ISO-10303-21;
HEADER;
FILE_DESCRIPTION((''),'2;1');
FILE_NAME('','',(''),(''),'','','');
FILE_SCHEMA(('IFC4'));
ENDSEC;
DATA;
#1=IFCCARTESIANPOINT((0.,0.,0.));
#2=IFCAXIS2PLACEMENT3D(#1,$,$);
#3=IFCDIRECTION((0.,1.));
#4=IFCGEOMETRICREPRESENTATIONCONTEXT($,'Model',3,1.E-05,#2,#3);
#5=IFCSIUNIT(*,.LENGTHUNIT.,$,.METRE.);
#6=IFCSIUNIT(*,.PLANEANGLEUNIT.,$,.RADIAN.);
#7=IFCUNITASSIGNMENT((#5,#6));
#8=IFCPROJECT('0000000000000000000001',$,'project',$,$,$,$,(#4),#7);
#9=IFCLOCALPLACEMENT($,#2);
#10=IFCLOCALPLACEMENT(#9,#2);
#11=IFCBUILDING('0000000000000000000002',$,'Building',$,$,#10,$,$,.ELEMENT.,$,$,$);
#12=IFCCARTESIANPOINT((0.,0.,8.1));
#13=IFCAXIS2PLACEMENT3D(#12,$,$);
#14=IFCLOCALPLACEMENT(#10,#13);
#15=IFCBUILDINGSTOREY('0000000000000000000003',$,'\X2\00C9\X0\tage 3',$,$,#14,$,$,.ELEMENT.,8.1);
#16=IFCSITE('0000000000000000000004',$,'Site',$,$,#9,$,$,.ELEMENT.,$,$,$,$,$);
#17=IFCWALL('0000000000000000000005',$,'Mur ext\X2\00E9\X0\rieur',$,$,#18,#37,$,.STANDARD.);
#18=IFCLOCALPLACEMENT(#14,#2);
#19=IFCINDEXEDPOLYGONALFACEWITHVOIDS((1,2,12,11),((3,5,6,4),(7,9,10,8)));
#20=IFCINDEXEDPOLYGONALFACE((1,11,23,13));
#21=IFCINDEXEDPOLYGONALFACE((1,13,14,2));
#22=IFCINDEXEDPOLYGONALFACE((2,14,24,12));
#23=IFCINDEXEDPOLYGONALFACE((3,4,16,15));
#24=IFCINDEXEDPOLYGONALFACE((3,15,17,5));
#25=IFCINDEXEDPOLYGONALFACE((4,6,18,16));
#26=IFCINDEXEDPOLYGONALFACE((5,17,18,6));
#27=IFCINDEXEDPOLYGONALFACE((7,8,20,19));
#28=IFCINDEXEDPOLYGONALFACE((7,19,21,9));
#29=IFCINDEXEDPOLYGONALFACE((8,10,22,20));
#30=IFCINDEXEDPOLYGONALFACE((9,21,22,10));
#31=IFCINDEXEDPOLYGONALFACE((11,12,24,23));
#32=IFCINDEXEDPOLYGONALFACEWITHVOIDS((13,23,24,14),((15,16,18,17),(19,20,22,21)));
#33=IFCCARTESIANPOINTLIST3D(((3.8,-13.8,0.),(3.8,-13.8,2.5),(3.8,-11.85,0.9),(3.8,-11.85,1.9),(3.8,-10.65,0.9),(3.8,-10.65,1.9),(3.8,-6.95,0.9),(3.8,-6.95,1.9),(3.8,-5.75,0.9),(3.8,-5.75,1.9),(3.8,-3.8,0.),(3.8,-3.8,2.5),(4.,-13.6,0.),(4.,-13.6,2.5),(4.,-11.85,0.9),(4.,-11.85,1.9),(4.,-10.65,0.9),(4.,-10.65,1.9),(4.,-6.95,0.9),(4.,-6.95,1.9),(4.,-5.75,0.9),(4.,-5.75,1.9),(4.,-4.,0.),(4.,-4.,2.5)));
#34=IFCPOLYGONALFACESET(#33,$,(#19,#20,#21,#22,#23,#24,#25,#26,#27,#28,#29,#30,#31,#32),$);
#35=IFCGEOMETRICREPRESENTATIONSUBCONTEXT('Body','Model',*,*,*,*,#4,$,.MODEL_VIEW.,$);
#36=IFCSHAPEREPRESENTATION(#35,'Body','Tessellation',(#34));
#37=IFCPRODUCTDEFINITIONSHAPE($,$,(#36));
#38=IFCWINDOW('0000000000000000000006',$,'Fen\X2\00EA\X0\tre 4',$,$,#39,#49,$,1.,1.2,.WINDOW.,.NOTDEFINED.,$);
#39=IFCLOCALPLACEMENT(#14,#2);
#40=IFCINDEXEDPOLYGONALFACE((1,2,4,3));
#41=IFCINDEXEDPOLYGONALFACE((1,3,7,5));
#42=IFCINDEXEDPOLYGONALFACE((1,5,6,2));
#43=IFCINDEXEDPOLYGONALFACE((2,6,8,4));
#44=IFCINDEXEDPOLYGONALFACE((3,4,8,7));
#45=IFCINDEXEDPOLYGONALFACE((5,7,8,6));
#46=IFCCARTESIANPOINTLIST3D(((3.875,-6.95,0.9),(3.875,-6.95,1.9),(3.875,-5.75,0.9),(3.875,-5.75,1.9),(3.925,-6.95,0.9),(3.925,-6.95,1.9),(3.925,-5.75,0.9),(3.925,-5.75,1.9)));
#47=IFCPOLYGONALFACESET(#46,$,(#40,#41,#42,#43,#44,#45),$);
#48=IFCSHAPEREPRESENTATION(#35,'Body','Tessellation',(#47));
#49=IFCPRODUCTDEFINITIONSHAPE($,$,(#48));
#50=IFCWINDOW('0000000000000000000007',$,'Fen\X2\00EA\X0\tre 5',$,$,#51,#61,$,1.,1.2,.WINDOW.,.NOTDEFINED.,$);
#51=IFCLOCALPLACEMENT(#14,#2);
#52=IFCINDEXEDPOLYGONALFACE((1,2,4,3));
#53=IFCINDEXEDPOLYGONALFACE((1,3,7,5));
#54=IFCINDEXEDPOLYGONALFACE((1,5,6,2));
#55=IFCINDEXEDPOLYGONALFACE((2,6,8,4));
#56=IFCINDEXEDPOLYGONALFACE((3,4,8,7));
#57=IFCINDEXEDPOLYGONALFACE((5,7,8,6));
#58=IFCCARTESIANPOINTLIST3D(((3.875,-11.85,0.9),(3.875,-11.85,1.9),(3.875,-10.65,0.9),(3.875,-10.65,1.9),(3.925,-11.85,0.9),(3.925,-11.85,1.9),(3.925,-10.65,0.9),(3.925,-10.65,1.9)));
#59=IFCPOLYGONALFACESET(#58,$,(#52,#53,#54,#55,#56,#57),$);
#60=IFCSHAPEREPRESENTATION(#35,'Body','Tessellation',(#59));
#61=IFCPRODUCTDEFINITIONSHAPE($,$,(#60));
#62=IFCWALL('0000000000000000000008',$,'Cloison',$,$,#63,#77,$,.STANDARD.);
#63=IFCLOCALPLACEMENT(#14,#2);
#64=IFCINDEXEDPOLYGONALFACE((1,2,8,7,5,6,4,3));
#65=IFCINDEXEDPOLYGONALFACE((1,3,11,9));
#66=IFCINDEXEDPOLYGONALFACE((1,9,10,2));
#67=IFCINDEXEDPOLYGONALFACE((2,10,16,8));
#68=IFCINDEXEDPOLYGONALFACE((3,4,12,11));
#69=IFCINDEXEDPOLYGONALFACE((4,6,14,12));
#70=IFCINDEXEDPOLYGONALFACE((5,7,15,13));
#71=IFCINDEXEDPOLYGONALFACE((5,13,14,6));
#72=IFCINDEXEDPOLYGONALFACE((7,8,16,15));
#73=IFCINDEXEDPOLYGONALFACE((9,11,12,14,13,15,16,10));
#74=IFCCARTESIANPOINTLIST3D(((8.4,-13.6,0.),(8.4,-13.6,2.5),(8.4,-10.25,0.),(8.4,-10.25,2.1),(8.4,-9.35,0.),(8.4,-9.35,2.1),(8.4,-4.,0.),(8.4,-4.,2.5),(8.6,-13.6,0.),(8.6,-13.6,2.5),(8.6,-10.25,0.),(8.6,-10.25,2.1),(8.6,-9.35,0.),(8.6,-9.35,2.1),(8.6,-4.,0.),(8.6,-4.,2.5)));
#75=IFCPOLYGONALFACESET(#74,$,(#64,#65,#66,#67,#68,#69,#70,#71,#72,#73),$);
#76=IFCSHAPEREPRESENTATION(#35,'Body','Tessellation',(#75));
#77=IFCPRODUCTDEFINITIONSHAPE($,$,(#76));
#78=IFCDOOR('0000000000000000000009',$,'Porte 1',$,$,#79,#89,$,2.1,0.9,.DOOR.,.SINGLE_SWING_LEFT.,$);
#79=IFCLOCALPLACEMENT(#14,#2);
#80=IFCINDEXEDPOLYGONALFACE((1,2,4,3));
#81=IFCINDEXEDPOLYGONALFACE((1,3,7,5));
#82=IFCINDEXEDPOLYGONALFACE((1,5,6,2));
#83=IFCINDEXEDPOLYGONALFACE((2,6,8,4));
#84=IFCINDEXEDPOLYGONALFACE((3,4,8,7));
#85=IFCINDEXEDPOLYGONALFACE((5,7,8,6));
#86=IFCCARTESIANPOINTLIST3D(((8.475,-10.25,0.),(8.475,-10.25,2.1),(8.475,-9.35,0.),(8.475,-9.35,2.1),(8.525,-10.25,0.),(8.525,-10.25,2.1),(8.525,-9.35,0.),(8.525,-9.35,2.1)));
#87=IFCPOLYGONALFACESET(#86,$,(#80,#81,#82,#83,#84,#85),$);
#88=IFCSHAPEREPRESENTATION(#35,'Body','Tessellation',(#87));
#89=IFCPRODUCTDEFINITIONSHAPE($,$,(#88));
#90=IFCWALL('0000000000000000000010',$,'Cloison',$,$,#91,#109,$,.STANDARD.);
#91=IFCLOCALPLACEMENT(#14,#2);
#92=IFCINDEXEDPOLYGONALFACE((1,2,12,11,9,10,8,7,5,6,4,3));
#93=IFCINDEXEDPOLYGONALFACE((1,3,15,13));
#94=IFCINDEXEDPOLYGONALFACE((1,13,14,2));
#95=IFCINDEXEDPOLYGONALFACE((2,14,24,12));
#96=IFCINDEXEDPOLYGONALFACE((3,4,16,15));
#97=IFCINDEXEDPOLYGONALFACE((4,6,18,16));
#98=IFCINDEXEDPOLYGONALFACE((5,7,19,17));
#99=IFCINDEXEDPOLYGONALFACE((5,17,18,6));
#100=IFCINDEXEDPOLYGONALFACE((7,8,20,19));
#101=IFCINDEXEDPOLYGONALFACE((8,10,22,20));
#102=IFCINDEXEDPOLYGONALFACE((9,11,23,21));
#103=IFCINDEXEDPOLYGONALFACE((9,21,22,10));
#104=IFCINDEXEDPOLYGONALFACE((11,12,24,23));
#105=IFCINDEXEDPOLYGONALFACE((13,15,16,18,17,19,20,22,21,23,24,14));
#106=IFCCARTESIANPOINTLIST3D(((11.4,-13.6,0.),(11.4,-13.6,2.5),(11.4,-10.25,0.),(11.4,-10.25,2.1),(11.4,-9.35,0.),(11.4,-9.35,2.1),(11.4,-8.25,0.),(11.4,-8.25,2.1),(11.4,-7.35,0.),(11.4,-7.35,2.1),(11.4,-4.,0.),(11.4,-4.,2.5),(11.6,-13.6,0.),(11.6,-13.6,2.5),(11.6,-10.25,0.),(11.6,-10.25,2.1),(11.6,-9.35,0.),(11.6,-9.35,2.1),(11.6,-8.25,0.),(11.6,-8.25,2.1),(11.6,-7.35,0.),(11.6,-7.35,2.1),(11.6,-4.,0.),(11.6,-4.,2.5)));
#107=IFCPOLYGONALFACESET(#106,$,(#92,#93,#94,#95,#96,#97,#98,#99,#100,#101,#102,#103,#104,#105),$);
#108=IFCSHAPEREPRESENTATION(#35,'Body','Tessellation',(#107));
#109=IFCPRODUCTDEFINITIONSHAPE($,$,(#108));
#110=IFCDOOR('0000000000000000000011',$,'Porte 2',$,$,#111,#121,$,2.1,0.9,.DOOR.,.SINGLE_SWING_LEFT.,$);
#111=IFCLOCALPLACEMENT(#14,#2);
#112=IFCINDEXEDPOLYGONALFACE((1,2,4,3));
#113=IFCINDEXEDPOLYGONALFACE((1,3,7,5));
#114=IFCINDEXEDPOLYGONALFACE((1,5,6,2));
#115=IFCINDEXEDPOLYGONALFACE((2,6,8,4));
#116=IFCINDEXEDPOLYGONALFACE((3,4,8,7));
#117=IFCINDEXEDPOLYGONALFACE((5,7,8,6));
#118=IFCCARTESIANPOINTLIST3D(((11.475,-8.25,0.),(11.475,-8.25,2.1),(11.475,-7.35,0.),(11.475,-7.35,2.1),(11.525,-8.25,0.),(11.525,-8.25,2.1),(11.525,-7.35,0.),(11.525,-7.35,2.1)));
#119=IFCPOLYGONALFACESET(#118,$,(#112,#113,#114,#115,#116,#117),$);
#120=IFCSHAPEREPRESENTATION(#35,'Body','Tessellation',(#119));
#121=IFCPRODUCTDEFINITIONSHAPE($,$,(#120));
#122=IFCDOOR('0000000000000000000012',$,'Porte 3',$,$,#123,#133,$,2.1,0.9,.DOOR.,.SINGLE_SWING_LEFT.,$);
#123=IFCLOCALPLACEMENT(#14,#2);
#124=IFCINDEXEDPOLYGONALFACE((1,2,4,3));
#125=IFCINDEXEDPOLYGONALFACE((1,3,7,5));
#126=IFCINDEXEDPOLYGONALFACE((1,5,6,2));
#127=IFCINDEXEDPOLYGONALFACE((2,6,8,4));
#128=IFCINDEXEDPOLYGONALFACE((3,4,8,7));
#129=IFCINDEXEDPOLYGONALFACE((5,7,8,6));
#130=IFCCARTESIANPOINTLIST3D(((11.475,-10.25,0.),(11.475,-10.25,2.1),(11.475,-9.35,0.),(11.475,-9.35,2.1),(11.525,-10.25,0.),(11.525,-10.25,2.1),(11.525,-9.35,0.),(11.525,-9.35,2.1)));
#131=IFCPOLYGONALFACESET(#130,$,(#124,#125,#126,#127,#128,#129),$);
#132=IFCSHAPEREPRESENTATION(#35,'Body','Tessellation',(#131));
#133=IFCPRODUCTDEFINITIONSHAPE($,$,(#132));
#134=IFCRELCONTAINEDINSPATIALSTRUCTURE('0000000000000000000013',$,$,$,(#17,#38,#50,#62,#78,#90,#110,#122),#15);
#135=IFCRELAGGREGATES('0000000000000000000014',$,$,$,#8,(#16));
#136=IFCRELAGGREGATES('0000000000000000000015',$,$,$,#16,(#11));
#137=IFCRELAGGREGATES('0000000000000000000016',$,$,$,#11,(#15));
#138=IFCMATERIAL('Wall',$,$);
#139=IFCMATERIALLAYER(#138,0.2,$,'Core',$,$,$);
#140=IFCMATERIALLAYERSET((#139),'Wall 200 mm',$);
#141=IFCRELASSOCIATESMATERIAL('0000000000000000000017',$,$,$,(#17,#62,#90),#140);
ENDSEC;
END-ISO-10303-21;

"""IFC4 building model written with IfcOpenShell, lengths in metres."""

from ifc_helpers import new_model, si_unit, direction, frame, origin, origin_2d, place, context, subcontext, project, spatial, polyline, rectangle, outline, extrude, material, layer, layer_set, layer_usage, element, fill, save


model = new_model("IFC4")

# Units and contexts
model_context = context("Model", 3, precision=1e-05, world=origin(), true_north=direction((0.0, 1.0)))
body_context = subcontext(model_context, "Body", "Model", "MODEL_VIEW")
ifc_project = project(units=[si_unit("LENGTHUNIT", "METRE"), si_unit("PLANEANGLEUNIT", "RADIAN")], contexts=[model_context])

# Site, building, storey
site_placement = place(None, origin())
site = spatial("IfcSite", under=ifc_project, at=site_placement, Name="Site", CompositionType="ELEMENT")
building_placement = place(site_placement, origin())
building = spatial("IfcBuilding", under=site, at=building_placement, Name="Building", CompositionType="ELEMENT")
storey_placement = place(building_placement, frame((0.0, 0.0, 8.1)))
storey = spatial("IfcBuildingStorey", under=building, at=storey_placement, Name="Étage 3", CompositionType="ELEMENT", Elevation=8.1)

# Shared definitions
ifc_material = material(Name="Wall")
ifc_layer = layer(ifc_material, 0.2, Name="Core")
ifc_layer_set = layer_set([ifc_layer], Name="Wall 200 mm")
ifc_layer_usage = layer_usage(ifc_layer_set, "AXIS2", "POSITIVE", -0.1)

# Wall, openings, windows
wall_1_placement = place(storey_placement, frame((3.9, -13.7, 0.0), z_axis=(0.0, 0.0, 1.0), x_axis=(0.0, 1.0, 0.0)))
wall_1 = element("IfcWall", 1, at=wall_1_placement, inside=storey, material=ifc_layer_usage, Name="Mur extérieur", PredefinedType="STANDARD", context=body_context, shape_type="SweptSolid", body=[
    extrude(outline(polyline([(0.0, 0.0), (0.1, -0.1), (9.7, -0.1), (9.8, 0.0), (9.9, 0.1), (-0.1, 0.1), (0.0, 0.0)])), origin(), (0.0, 0.0, 1.0), 2.5),
])
opening_1_placement = place(wall_1_placement, frame((7.35, 0.0, 0.9)))
opening_1 = element("IfcOpeningElement", 2, at=opening_1_placement, cuts=wall_1, PredefinedType="OPENING", context=body_context, shape_type="SweptSolid", body=[
    extrude(rectangle(XDim=1.2, YDim=0.4, at=origin_2d()), origin(), (0.0, 0.0, 1.0), 1.0),
])
opening_2_placement = place(wall_1_placement, frame((2.45, 0.0, 0.9)))
opening_2 = element("IfcOpeningElement", 3, at=opening_2_placement, cuts=wall_1, PredefinedType="OPENING", context=body_context, shape_type="SweptSolid", body=[
    extrude(rectangle(XDim=1.2, YDim=0.4, at=origin_2d()), origin(), (0.0, 0.0, 1.0), 1.0),
])
window_1_placement = place(opening_1_placement, origin())
window_1 = element("IfcWindow", 4, at=window_1_placement, inside=storey, Name="Fenêtre 4", OverallHeight=1.0, OverallWidth=1.2, PartitioningType="NOTDEFINED", PredefinedType="WINDOW", context=body_context, shape_type="SweptSolid", body=[
    extrude(rectangle(XDim=1.2, YDim=0.05, at=origin_2d()), origin(), (0.0, 0.0, 1.0), 1.0),
])
fill(opening_1, window_1)
window_2_placement = place(opening_2_placement, origin())
window_2 = element("IfcWindow", 5, at=window_2_placement, inside=storey, Name="Fenêtre 5", OverallHeight=1.0, OverallWidth=1.2, PartitioningType="NOTDEFINED", PredefinedType="WINDOW", context=body_context, shape_type="SweptSolid", body=[
    extrude(rectangle(XDim=1.2, YDim=0.05, at=origin_2d()), origin(), (0.0, 0.0, 1.0), 1.0),
])
fill(opening_2, window_2)

# Wall, opening, door
wall_2_placement = place(storey_placement, frame((8.5, -3.9, 0.0), z_axis=(0.0, 0.0, 1.0), x_axis=(0.0, -1.0, 0.0)))
wall_2 = element("IfcWall", 6, at=wall_2_placement, inside=storey, material=ifc_layer_usage, Name="Cloison", PredefinedType="STANDARD", context=body_context, shape_type="SweptSolid", body=[
    extrude(outline(polyline([(0.1, 0.0), (0.1, -0.1), (9.7, -0.1), (9.7, 0.0), (9.7, 0.1), (0.1, 0.1), (0.1, 0.0)])), origin(), (0.0, 0.0, 1.0), 2.5),
])
opening_3_placement = place(wall_2_placement, frame((5.9, 0.0, 0.0)))
opening_3 = element("IfcOpeningElement", 7, at=opening_3_placement, cuts=wall_2, PredefinedType="OPENING", context=body_context, shape_type="SweptSolid", body=[
    extrude(rectangle(XDim=0.9, YDim=0.4, at=origin_2d()), origin(), (0.0, 0.0, 1.0), 2.1),
])
door_1_placement = place(opening_3_placement, origin())
door_1 = element("IfcDoor", 8, at=door_1_placement, inside=storey, Name="Porte 1", OperationType="SINGLE_SWING_LEFT", OverallHeight=2.1, OverallWidth=0.9, PredefinedType="DOOR", context=body_context, shape_type="SweptSolid", body=[
    extrude(rectangle(XDim=0.9, YDim=0.05, at=origin_2d()), origin(), (0.0, 0.0, 1.0), 2.1),
])
fill(opening_3, door_1)

# Wall, openings, doors
wall_3_placement = place(storey_placement, frame((11.5, -3.9, 0.0), z_axis=(0.0, 0.0, 1.0), x_axis=(0.0, -1.0, 0.0)))
wall_3 = element("IfcWall", 9, at=wall_3_placement, inside=storey, material=ifc_layer_usage, Name="Cloison", PredefinedType="STANDARD", context=body_context, shape_type="SweptSolid", body=[
    extrude(outline(polyline([(0.1, 0.0), (0.1, -0.1), (9.7, -0.1), (9.7, 0.0), (9.7, 0.1), (0.1, 0.1), (0.1, 0.0)])), origin(), (0.0, 0.0, 1.0), 2.5),
])
opening_4_placement = place(wall_3_placement, frame((3.9, 0.0, 0.0)))
opening_4 = element("IfcOpeningElement", 10, at=opening_4_placement, cuts=wall_3, PredefinedType="OPENING", context=body_context, shape_type="SweptSolid", body=[
    extrude(rectangle(XDim=0.9, YDim=0.4, at=origin_2d()), origin(), (0.0, 0.0, 1.0), 2.1),
])
opening_5_placement = place(wall_3_placement, frame((5.9, 0.0, 0.0)))
opening_5 = element("IfcOpeningElement", 11, at=opening_5_placement, cuts=wall_3, PredefinedType="OPENING", context=body_context, shape_type="SweptSolid", body=[
    extrude(rectangle(XDim=0.9, YDim=0.4, at=origin_2d()), origin(), (0.0, 0.0, 1.0), 2.1),
])
door_2_placement = place(opening_4_placement, origin())
door_2 = element("IfcDoor", 12, at=door_2_placement, inside=storey, Name="Porte 2", OperationType="SINGLE_SWING_LEFT", OverallHeight=2.1, OverallWidth=0.9, PredefinedType="DOOR", context=body_context, shape_type="SweptSolid", body=[
    extrude(rectangle(XDim=0.9, YDim=0.05, at=origin_2d()), origin(), (0.0, 0.0, 1.0), 2.1),
])
fill(opening_4, door_2)
door_3_placement = place(opening_5_placement, origin())
door_3 = element("IfcDoor", 13, at=door_3_placement, inside=storey, Name="Porte 3", OperationType="SINGLE_SWING_LEFT", OverallHeight=2.1, OverallWidth=0.9, PredefinedType="DOOR", context=body_context, shape_type="SweptSolid", body=[
    extrude(rectangle(XDim=0.9, YDim=0.05, at=origin_2d()), origin(), (0.0, 0.0, 1.0), 2.1),
])
fill(opening_5, door_3)

save(model, "model.ifc")
